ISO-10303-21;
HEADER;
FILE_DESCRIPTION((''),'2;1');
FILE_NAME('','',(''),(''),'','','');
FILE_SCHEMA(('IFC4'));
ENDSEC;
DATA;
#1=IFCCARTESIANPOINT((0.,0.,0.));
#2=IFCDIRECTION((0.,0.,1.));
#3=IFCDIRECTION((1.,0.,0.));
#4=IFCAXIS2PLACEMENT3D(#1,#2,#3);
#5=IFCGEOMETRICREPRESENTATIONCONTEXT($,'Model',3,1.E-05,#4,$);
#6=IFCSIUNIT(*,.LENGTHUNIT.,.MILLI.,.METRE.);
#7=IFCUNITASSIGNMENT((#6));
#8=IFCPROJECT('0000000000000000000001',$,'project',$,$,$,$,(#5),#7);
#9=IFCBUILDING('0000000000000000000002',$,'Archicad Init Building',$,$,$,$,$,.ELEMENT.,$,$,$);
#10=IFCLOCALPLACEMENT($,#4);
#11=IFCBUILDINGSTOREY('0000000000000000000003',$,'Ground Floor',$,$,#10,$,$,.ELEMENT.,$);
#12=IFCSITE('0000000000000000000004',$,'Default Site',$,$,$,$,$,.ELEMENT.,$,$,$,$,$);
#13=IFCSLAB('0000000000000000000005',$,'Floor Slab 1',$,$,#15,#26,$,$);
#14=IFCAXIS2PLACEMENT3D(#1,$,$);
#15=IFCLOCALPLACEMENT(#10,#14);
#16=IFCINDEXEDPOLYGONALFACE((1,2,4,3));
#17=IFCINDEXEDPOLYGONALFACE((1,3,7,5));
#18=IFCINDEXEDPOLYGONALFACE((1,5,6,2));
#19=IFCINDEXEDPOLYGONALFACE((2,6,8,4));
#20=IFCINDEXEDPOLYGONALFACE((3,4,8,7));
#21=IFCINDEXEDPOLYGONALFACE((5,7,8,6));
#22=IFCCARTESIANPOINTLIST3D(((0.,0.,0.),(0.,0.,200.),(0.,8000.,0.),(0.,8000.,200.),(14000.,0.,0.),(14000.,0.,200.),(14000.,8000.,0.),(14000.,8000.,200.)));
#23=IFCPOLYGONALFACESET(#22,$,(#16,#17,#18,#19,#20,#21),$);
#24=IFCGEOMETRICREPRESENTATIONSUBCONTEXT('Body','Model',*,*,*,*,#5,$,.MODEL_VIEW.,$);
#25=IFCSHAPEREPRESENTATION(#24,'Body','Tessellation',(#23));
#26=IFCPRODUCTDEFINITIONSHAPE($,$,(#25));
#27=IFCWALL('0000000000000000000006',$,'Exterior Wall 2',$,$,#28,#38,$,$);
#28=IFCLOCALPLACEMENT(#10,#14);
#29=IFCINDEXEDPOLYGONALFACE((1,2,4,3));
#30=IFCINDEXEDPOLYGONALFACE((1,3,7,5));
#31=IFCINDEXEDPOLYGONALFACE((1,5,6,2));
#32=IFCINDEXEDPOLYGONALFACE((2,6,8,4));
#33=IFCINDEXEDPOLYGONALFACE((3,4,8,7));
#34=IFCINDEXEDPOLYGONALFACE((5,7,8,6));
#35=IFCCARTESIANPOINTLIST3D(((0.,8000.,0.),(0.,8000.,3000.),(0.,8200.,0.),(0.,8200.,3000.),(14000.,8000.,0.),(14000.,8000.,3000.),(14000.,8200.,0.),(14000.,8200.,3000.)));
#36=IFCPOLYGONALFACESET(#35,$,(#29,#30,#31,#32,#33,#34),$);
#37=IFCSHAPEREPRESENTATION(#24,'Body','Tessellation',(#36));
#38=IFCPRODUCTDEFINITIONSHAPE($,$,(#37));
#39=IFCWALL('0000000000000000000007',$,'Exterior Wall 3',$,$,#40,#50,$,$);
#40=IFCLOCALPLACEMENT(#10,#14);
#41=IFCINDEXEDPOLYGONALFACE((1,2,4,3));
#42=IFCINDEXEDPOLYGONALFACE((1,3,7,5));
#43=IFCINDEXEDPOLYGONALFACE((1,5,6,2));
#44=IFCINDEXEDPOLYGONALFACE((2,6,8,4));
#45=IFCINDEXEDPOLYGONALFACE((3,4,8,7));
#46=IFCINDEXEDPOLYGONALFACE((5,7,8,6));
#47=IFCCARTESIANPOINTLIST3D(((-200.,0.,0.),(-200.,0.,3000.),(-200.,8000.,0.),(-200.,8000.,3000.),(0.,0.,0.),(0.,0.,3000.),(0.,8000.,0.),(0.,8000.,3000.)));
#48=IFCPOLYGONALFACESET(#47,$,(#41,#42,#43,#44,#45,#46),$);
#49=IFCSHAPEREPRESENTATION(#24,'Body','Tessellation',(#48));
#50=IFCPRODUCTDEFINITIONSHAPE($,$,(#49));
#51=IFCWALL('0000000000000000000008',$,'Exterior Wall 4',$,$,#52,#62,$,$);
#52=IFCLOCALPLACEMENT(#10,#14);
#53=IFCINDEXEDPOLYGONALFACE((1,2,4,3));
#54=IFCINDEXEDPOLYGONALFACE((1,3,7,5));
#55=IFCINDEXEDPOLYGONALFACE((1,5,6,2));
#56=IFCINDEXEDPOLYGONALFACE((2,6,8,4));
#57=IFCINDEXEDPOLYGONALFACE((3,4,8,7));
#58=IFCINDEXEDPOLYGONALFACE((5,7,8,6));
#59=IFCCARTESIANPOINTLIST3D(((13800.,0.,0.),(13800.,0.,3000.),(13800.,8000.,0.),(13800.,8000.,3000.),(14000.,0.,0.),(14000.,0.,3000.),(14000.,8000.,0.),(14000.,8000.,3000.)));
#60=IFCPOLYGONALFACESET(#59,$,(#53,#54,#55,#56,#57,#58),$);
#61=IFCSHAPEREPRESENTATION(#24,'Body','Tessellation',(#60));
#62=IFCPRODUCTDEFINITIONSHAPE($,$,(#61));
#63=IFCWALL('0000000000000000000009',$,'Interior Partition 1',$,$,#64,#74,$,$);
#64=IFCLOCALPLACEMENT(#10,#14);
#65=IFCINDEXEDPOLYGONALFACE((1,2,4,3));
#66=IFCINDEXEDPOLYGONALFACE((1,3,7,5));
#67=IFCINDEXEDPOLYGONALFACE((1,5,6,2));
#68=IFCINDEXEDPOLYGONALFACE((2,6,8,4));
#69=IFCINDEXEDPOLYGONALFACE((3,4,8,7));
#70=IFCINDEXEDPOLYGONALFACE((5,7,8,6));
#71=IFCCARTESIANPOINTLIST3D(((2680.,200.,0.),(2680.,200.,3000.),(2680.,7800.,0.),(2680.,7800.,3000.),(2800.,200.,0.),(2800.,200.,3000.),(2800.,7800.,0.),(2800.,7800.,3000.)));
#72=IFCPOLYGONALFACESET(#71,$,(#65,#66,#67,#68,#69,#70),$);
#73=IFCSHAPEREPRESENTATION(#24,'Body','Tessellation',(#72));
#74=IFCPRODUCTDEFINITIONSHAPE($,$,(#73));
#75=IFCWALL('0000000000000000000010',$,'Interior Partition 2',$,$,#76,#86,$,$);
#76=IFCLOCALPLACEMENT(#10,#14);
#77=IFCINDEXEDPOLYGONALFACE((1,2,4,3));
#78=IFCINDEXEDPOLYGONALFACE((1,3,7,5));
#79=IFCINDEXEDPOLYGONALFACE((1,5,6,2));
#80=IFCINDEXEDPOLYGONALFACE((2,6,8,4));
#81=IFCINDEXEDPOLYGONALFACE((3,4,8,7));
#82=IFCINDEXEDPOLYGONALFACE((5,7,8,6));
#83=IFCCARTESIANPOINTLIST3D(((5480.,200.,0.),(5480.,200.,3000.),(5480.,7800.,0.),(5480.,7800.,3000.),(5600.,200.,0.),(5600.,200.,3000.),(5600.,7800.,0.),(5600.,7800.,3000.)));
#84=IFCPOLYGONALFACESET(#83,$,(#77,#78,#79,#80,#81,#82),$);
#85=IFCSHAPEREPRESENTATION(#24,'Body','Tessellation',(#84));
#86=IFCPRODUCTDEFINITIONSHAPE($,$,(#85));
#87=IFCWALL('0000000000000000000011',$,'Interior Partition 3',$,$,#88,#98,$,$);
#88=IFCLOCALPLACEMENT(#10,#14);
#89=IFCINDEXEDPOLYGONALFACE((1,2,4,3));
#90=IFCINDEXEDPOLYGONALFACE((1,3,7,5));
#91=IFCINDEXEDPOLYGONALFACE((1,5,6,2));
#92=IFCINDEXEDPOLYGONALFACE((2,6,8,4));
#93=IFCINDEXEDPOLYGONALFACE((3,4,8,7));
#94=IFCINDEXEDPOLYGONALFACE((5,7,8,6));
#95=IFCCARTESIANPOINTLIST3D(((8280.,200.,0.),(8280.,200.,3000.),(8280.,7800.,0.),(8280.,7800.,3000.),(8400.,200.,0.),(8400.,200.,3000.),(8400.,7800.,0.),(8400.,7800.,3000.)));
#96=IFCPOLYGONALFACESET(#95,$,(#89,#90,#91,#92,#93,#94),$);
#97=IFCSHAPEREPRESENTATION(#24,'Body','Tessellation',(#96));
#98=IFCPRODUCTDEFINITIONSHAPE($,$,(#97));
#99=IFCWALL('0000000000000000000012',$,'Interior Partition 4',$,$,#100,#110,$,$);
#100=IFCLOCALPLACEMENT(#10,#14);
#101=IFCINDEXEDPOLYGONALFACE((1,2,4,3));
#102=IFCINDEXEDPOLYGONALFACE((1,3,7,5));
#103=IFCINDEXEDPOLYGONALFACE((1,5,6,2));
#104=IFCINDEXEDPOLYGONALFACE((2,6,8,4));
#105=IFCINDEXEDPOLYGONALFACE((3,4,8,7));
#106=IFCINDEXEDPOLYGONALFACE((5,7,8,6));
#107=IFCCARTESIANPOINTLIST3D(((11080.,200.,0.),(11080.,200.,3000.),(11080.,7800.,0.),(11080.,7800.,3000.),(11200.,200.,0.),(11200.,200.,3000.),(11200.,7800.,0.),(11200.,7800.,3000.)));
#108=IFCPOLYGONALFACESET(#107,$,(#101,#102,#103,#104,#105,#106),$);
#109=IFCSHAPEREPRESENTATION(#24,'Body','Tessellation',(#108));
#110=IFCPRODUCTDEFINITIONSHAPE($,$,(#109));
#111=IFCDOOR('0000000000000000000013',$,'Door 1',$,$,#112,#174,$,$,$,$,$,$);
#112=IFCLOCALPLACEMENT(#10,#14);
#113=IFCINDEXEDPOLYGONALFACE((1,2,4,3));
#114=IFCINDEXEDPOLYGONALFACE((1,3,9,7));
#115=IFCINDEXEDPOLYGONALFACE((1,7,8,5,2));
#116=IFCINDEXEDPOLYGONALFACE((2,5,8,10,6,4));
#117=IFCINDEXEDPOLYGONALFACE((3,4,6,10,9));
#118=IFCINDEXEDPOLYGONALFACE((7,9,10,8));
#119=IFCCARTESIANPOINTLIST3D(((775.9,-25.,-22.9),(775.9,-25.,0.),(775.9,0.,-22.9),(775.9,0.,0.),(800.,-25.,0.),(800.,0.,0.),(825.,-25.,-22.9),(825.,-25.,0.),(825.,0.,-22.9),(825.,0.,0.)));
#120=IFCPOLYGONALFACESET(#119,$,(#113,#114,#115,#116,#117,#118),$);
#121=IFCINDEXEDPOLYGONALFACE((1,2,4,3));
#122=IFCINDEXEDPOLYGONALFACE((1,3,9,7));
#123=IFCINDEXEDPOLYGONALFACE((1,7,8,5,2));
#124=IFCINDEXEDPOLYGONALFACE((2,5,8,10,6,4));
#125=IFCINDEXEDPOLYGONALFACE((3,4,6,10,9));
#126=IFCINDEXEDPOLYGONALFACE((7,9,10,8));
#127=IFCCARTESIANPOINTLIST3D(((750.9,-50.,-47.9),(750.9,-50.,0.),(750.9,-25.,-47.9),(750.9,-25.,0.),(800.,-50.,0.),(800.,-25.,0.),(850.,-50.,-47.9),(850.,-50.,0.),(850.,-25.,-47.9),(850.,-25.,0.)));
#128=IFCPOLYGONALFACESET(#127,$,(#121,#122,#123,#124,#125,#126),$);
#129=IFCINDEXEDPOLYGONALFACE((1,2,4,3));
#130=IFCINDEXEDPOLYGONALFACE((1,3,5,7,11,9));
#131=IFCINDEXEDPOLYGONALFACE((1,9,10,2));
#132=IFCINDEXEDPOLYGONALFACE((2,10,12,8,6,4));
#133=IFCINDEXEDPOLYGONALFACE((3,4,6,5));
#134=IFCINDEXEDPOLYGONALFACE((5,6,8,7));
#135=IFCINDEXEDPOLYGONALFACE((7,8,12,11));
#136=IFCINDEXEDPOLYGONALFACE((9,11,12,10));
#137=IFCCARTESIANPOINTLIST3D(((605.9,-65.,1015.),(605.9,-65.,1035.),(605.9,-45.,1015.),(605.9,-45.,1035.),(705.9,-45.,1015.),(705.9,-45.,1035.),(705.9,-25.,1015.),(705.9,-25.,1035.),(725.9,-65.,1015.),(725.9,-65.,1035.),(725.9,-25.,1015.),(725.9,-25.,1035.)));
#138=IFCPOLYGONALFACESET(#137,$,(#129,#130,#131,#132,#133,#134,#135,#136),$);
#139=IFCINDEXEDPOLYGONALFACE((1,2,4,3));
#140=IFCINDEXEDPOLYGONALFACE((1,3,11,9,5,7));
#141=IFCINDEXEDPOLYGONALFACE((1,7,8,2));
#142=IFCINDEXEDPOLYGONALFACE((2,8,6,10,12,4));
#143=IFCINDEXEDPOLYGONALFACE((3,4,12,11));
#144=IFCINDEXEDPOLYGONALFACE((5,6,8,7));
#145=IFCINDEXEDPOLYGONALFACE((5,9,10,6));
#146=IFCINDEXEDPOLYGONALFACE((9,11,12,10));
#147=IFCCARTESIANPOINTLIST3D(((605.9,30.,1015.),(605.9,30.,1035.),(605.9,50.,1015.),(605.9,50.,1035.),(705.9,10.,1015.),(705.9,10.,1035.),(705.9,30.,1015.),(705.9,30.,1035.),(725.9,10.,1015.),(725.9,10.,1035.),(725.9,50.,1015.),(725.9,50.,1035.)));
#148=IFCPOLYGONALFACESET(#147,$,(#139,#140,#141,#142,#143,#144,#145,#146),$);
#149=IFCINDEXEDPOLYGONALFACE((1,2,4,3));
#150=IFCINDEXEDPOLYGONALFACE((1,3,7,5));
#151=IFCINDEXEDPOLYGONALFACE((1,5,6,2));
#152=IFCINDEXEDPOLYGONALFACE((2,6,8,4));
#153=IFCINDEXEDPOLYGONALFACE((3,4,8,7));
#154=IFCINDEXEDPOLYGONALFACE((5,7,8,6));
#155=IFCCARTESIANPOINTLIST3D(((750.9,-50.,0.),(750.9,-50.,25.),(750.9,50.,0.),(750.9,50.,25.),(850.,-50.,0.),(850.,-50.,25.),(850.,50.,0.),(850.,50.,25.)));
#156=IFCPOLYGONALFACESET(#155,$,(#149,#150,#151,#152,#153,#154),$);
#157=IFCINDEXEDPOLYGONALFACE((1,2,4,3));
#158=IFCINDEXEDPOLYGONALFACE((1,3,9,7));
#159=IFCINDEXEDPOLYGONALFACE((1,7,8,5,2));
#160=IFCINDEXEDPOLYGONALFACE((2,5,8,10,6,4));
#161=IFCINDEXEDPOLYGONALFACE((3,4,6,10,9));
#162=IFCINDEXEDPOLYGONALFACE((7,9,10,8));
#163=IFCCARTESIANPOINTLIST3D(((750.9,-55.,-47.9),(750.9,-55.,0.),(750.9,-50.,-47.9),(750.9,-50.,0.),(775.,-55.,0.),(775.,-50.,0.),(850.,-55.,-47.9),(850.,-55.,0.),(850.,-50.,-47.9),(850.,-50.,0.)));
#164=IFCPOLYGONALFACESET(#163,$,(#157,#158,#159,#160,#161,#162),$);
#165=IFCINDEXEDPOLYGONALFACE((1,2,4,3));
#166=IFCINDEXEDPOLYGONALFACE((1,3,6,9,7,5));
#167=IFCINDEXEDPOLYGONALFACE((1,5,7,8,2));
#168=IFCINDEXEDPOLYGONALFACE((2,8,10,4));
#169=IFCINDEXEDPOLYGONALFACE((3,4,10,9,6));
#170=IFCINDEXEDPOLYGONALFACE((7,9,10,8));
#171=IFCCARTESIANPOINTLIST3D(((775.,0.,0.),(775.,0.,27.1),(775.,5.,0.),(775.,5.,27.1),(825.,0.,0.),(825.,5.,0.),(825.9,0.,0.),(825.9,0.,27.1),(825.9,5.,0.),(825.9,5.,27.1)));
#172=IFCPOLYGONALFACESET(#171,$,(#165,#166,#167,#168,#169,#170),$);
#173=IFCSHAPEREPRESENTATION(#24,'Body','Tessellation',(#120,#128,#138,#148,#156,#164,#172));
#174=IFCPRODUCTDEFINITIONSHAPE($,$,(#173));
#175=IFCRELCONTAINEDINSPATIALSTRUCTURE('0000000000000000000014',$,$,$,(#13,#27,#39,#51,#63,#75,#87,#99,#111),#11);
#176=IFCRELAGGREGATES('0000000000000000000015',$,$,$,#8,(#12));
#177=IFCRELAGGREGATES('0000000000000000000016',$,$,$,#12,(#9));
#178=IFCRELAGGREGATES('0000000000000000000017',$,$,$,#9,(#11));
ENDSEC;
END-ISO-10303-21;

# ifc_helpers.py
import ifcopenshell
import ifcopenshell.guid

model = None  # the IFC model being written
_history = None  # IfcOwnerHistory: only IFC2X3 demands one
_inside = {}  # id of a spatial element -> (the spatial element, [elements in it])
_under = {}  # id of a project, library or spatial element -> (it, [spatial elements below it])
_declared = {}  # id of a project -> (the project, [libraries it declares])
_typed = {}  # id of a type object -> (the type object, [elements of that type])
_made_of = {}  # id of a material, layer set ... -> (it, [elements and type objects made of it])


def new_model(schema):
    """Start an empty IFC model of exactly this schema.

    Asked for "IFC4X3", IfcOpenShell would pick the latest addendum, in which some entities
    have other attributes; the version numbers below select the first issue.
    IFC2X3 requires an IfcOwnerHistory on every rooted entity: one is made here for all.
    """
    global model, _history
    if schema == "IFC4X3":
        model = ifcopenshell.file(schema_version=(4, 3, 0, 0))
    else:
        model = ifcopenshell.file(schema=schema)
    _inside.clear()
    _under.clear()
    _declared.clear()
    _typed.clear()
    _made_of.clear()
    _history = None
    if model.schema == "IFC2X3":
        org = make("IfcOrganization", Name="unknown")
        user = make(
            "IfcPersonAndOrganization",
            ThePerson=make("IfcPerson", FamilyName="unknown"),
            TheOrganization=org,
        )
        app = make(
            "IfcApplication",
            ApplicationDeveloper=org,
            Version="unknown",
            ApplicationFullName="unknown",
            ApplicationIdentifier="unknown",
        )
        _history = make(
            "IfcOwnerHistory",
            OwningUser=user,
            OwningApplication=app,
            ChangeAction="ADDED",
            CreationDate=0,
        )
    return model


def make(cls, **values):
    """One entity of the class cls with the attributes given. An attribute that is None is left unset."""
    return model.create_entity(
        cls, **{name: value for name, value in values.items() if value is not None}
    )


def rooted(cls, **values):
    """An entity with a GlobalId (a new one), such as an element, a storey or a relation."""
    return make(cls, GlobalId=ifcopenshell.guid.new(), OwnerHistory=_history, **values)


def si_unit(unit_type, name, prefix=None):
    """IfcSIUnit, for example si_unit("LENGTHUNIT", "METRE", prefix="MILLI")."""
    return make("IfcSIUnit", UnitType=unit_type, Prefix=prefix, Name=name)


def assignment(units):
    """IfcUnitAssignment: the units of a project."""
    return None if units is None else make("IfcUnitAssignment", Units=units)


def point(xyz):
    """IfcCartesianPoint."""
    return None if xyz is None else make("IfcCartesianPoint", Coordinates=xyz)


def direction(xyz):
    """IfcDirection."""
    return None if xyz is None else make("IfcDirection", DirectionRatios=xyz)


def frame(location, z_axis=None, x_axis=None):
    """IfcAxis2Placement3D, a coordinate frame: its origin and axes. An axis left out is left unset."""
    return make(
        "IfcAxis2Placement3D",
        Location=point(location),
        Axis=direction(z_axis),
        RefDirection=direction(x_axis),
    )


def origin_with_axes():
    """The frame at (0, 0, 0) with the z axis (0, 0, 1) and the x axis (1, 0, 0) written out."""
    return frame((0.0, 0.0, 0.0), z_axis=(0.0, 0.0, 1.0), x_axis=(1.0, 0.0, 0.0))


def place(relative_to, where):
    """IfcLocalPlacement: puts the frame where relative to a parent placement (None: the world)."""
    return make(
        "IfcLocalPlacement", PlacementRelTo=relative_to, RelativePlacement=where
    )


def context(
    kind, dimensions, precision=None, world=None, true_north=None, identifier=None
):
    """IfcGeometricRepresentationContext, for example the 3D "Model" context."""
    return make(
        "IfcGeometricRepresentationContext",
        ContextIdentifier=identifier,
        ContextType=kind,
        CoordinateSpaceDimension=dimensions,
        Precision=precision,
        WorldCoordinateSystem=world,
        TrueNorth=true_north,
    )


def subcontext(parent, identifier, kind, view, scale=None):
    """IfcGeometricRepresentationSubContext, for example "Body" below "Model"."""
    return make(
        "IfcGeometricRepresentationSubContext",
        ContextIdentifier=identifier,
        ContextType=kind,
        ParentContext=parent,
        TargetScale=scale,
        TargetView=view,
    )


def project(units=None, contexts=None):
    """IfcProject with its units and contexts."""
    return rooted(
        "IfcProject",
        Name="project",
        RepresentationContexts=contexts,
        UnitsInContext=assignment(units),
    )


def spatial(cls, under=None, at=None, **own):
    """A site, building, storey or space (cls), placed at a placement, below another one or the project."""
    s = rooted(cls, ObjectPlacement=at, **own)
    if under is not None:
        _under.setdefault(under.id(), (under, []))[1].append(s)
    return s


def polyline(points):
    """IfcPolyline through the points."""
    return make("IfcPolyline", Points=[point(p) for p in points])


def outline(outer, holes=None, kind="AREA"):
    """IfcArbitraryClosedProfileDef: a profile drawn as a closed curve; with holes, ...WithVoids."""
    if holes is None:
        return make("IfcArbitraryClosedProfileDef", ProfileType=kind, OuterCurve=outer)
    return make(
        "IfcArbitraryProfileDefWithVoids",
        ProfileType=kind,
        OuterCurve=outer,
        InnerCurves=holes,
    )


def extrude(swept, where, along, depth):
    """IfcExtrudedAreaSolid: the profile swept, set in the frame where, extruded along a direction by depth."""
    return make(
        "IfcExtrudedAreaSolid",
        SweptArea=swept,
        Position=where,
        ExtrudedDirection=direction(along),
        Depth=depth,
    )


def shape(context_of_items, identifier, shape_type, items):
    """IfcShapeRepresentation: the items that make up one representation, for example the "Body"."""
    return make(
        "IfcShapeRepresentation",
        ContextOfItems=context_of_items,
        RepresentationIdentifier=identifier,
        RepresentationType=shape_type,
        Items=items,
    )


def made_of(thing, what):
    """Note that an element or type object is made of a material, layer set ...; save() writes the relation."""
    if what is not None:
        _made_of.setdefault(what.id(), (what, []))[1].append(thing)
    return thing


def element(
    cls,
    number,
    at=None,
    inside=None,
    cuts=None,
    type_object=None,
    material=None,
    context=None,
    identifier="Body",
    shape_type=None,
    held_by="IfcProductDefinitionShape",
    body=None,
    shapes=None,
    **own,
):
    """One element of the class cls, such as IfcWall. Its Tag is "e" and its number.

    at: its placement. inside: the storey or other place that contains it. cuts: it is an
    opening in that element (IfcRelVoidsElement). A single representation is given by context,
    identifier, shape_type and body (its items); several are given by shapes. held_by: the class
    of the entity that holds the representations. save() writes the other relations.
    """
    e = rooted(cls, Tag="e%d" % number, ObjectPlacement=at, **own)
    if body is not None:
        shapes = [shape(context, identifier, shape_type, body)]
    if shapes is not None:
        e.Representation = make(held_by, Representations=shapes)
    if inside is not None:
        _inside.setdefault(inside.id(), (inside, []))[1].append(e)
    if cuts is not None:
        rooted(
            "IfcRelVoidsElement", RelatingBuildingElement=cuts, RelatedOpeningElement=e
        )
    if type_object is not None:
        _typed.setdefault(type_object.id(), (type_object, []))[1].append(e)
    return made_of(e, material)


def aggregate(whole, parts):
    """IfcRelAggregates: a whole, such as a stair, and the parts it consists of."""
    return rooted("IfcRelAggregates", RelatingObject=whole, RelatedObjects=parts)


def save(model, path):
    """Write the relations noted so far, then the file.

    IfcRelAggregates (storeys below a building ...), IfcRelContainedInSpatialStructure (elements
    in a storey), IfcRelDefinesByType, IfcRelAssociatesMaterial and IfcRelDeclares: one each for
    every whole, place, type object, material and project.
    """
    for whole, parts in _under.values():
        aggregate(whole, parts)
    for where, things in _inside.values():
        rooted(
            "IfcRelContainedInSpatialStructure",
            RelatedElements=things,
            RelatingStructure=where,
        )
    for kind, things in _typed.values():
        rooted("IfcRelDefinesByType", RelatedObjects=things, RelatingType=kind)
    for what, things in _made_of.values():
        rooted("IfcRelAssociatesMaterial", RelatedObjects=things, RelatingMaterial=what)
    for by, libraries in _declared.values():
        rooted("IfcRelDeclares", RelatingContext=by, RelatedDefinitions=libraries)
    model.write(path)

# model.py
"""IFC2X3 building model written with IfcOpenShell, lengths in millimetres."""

from ifc_helpers import new_model, si_unit, frame, origin_with_axes, place, context, subcontext, project, spatial, polyline, outline, extrude, element, save


model = new_model("IFC2X3")

# Units and contexts
model_context = context("Model", 3, precision=1e-05, world=origin_with_axes())
body_context = subcontext(model_context, "Body", "Model", "MODEL_VIEW")
ifc_project = project(units=[si_unit("LENGTHUNIT", "METRE", prefix="MILLI")], contexts=[model_context])

# Site, building, storey
site = spatial("IfcSite", under=ifc_project, Name="Default Site", CompositionType="ELEMENT")
building = spatial("IfcBuilding", under=site, Name="Archicad Init Building", CompositionType="ELEMENT")
storey_placement = place(None, origin_with_axes())
storey = spatial("IfcBuildingStorey", under=building, at=storey_placement, Name="Ground Floor", CompositionType="ELEMENT")

# Slab
slab_placement = place(storey_placement, origin_with_axes())
element("IfcSlab", 1, at=slab_placement, inside=storey, Name="Floor Slab 1", context=body_context, shape_type="SweptSolid", body=[
    extrude(outline(polyline([(0.0, 0.0), (14000.0, 0.0), (14000.0, 8000.0), (0.0, 8000.0), (0.0, 0.0)])), origin_with_axes(), (0.0, 0.0, 1.0), 200.0),
])

# Walls
wall_placement = place(storey_placement, frame((0.0, 8000.0, 0.0), z_axis=(0.0, 0.0, 1.0), x_axis=(1.0, 0.0, 0.0)))
element("IfcWall", 2, at=wall_placement, inside=storey, Name="Exterior Wall 2", context=body_context, shape_type="SweptSolid", body=[
    extrude(outline(polyline([(0.0, 0.0), (0.0, 200.0), (14000.0, 200.0), (14000.0, 0.0), (0.0, 0.0)])), origin_with_axes(), (0.0, 0.0, 1.0), 3000.0),
])
for number, where, z_axis, x_axis, name in (
    (3, (0.0, 0.0, 0.0), (0.0, 0.0, 1.0), (0.0, 1.0, 0.0), "Exterior Wall 3"),
    (4, (14000.0, 0.0, 0.0), (0.0, 0.0, 1.0), (0.0, 1.0, 0.0), "Exterior Wall 4"),
):
    element("IfcWall", number, at=place(storey_placement, frame(where, z_axis=z_axis, x_axis=x_axis)), inside=storey, Name=name, context=body_context, shape_type="SweptSolid", body=[
        extrude(outline(polyline([(0.0, 0.0), (0.0, 200.0), (8000.0, 200.0), (8000.0, 0.0), (0.0, 0.0)])), origin_with_axes(), (0.0, 0.0, 1.0), 3000.0),
    ])
for number, where, z_axis, x_axis, name in (
    (5, (2800.0, 200.0, 0.0), (0.0, 0.0, 1.0), (0.0, 1.0, 0.0), "Interior Partition 1"),
    (6, (5600.0, 200.0, 0.0), (0.0, 0.0, 1.0), (0.0, 1.0, 0.0), "Interior Partition 2"),
    (7, (8400.0, 200.0, 0.0), (0.0, 0.0, 1.0), (0.0, 1.0, 0.0), "Interior Partition 3"),
    (8, (11200.0, 200.0, 0.0), (0.0, 0.0, 1.0), (0.0, 1.0, 0.0), "Interior Partition 4"),
):
    element("IfcWall", number, at=place(storey_placement, frame(where, z_axis=z_axis, x_axis=x_axis)), inside=storey, Name=name, context=body_context, shape_type="SweptSolid", body=[
        extrude(outline(polyline([(0.0, 0.0), (0.0, 120.0), (7600.0, 120.0), (7600.0, 0.0), (0.0, 0.0)])), origin_with_axes(), (0.0, 0.0, 1.0), 3000.0),
    ])

# Door
door_1_placement = place(storey_placement, frame((800.0, -50.0, 0.0), z_axis=(0.0, 0.0, 1.0), x_axis=(1.0, 0.0, 0.0)))
element("IfcDoor", 9, at=door_1_placement, inside=storey, Name="Door 1", context=body_context, shape_type="SweptSolid", body=[
    extrude(outline(polyline([(0.0, 0.0), (0.0, 2.1), (0.9, 2.1), (0.9, 0.0), (-24.1, 0.0), (-24.1, -22.9), (25.0, -22.9), (25.0, 0.0), (0.0, 0.0)])), frame((0.0, 25.0, 0.0), z_axis=(0.0, -1.0, 0.0), x_axis=(1.0, 0.0, 0.0)), (0.0, 0.0, -1.0), 25.0),
    extrude(outline(polyline([(0.0, 0.0), (0.0, 2.1), (0.9, 2.1), (0.9, 0.0), (-49.1, 0.0), (-49.1, -47.9), (50.0, -47.9), (50.0, 0.0), (0.0, 0.0)])), frame((0.0, 0.0, 0.0), z_axis=(0.0, -1.0, 0.0), x_axis=(1.0, 0.0, 0.0)), (0.0, 0.0, -1.0), 25.0),
    extrude(outline(polyline([(0.0, 0.0), (-49.1, 0.0), (-49.1, 35.0), (0.0, 35.0), (0.0, 0.0)])), frame((25.0, 25.0, 25.0), z_axis=(0.0, 0.0, 1.0), x_axis=(1.0, 0.0, 0.0)), (0.0, 0.0, 1.0), -47.9),
    extrude(outline(polyline([(0.0, 0.0), (0.0, -40.0), (-120.0, -40.0), (-120.0, -20.0), (-20.0, -20.0), (-20.0, 0.0), (0.0, 0.0)])), frame((-74.1, 25.0, 1015.0), z_axis=(0.0, 0.0, 1.0), x_axis=(1.0, 0.0, 0.0)), (0.0, 0.0, 1.0), 20.0),
    extrude(outline(polyline([(0.0, 0.0), (0.0, 40.0), (-120.0, 40.0), (-120.0, 20.0), (-20.0, 20.0), (-20.0, 0.0), (0.0, 0.0)])), frame((-74.1, 60.0, 1015.0), z_axis=(0.0, 0.0, 1.0), x_axis=(1.0, 0.0, 0.0)), (0.0, 0.0, 1.0), 20.0),
    extrude(outline(polyline([(0.0, 0.0), (-99.1, 0.0), (-99.1, 100.0), (0.0, 100.0), (0.0, 0.0)])), frame((50.0, 0.0, 0.0), z_axis=(0.0, 0.0, 1.0), x_axis=(1.0, 0.0, 0.0)), (0.0, 0.0, 1.0), 25.0),
    extrude(outline(polyline([(0.0, 0.0), (0.0, 27.1), (50.9, 27.1), (50.9, 0.0), (-24.1, 0.0), (-24.1, -47.9), (75.0, -47.9), (75.0, 0.0), (0.0, 0.0)])), frame((-25.0, -5.0, 0.0), z_axis=(0.0, -1.0, 0.0), x_axis=(1.0, 0.0, 0.0)), (0.0, 0.0, -1.0), 5.0),
    extrude(outline(polyline([(0.0, 0.0), (0.0, 27.1), (50.9, 27.1), (50.9, 0.0), (0.9, 0.0), (0.9, -22.9), (50.0, -22.9), (50.0, 0.0), (0.0, 0.0)])), frame((-25.0, 50.0, 0.0), z_axis=(0.0, -1.0, 0.0), x_axis=(1.0, 0.0, 0.0)), (0.0, 0.0, -1.0), 5.0),
])

save(model, "model.ifc")
